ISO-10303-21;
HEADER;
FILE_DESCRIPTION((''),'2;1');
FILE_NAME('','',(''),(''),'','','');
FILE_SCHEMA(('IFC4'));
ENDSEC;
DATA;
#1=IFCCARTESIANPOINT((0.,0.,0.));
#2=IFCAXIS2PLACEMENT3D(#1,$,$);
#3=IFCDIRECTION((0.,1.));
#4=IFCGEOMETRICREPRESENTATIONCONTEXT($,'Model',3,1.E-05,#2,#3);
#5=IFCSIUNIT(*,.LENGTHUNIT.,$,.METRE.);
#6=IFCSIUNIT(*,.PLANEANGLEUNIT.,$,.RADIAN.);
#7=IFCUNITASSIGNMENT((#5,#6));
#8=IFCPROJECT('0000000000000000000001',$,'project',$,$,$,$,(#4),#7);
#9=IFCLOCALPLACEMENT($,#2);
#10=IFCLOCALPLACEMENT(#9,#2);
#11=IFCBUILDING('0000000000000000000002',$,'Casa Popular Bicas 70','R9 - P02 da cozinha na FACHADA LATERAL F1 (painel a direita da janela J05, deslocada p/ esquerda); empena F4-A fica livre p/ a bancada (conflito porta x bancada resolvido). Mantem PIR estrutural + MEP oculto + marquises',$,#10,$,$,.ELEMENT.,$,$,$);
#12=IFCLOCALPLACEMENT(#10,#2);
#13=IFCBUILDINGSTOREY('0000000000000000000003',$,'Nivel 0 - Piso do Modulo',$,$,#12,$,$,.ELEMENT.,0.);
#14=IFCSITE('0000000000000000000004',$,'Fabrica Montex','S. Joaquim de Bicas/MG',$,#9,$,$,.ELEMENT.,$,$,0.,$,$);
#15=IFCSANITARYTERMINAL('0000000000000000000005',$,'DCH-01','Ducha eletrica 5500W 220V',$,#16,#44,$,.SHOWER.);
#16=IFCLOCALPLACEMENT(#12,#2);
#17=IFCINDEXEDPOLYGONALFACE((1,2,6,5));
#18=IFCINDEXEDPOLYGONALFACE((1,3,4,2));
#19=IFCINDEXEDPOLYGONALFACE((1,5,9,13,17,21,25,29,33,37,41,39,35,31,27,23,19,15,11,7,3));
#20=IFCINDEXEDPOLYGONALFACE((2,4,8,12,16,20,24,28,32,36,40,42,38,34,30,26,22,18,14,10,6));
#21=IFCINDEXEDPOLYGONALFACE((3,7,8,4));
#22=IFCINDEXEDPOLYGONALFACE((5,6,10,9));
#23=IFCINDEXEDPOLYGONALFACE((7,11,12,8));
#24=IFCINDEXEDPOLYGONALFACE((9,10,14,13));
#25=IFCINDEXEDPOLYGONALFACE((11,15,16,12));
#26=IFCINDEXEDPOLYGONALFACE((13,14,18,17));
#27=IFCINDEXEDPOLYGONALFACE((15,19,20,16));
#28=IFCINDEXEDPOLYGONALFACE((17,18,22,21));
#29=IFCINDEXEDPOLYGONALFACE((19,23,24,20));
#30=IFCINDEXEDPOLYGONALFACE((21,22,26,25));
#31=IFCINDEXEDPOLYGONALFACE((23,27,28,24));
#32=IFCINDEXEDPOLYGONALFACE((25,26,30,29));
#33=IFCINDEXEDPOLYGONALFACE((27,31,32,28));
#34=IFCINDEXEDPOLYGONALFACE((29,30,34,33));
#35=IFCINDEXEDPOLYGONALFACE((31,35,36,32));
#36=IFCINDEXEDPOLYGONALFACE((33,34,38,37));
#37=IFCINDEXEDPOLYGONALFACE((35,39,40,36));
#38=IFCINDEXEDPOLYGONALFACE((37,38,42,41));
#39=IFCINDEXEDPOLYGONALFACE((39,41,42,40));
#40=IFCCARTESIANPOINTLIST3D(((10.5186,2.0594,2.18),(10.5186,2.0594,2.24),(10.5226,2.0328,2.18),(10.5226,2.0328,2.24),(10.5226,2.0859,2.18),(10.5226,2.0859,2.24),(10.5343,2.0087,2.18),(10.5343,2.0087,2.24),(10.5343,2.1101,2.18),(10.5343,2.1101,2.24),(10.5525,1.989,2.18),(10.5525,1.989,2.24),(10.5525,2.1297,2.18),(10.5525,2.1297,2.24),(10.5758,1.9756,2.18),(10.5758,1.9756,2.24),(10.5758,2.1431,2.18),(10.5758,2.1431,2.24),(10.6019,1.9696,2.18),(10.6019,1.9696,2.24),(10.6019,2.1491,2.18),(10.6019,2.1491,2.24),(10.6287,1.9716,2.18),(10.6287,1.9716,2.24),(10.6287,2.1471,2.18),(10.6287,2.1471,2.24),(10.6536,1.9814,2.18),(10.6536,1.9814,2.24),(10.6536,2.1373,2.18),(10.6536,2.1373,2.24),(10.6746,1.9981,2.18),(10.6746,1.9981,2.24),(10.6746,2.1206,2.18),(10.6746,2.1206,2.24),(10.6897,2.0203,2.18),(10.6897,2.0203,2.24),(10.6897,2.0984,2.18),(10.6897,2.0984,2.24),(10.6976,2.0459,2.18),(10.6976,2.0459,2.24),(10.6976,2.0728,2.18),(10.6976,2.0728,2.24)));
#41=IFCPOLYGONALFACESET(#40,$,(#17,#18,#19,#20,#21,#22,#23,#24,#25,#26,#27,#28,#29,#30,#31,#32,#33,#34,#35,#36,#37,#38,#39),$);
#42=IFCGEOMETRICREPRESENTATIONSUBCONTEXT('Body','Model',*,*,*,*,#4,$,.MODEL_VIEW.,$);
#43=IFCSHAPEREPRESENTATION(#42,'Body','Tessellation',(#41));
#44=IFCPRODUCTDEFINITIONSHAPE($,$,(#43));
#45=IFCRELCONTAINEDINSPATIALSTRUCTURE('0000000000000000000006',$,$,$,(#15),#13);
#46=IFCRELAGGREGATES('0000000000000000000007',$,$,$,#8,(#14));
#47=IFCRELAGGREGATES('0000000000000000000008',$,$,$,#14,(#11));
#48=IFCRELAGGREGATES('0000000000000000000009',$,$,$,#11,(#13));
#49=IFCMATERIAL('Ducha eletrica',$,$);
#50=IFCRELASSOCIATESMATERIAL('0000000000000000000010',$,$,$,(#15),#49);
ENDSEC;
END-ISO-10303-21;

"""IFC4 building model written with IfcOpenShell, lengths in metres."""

from ifc_helpers import new_model, si_unit, direction, frame, origin, origin_2d, place, context, subcontext, project, spatial, circle, extrude, material, element, save


model = new_model("IFC4")

# Units and contexts
model_context = context("Model", 3, precision=1e-05, world=origin(), true_north=direction((0.0, 1.0)))
body_context = subcontext(model_context, "Body", "Model", "MODEL_VIEW")
ifc_project = project(units=[si_unit("LENGTHUNIT", "METRE"), si_unit("PLANEANGLEUNIT", "RADIAN")], contexts=[model_context])

# Site, building, storey
site_placement = place(None, origin())
site = spatial("IfcSite", under=ifc_project, at=site_placement, Name="Fabrica Montex", Description="S. Joaquim de Bicas/MG", CompositionType="ELEMENT", RefElevation=0.0)
building_placement = place(site_placement, origin())
building = spatial("IfcBuilding", under=site, at=building_placement, Name="Casa Popular Bicas 70", Description="R9 - P02 da cozinha na FACHADA LATERAL F1 (painel a direita da janela J05, deslocada p/ esquerda); empena F4-A fica livre p/ a bancada (conflito porta x bancada resolvido). Mantem PIR estrutural + MEP oculto + marquises", CompositionType="ELEMENT")
storey_placement = place(building_placement, origin())
storey = spatial("IfcBuildingStorey", under=building, at=storey_placement, Name="Nivel 0 - Piso do Modulo", CompositionType="ELEMENT", Elevation=0.0)

# Sanitary terminal
ifc_material_1 = material(Name="Ducha eletrica")
sanitary_terminal_placement = place(None, frame((10.6086, 2.0594, 2.18), z_axis=(0.0, 0.0, 1.0), x_axis=(-1.0, 0.0, 0.0)))
element("IfcSanitaryTerminal", 1, at=sanitary_terminal_placement, inside=storey, material=ifc_material_1, Name="DCH-01", Description="Ducha eletrica 5500W 220V", PredefinedType="SHOWER", context=body_context, shape_type="SweptSolid", body=[
    extrude(circle(Radius=0.09, at=origin_2d()), origin(), (0.0, 0.0, 1.0), 0.06),
])

save(model, "model.ifc")
